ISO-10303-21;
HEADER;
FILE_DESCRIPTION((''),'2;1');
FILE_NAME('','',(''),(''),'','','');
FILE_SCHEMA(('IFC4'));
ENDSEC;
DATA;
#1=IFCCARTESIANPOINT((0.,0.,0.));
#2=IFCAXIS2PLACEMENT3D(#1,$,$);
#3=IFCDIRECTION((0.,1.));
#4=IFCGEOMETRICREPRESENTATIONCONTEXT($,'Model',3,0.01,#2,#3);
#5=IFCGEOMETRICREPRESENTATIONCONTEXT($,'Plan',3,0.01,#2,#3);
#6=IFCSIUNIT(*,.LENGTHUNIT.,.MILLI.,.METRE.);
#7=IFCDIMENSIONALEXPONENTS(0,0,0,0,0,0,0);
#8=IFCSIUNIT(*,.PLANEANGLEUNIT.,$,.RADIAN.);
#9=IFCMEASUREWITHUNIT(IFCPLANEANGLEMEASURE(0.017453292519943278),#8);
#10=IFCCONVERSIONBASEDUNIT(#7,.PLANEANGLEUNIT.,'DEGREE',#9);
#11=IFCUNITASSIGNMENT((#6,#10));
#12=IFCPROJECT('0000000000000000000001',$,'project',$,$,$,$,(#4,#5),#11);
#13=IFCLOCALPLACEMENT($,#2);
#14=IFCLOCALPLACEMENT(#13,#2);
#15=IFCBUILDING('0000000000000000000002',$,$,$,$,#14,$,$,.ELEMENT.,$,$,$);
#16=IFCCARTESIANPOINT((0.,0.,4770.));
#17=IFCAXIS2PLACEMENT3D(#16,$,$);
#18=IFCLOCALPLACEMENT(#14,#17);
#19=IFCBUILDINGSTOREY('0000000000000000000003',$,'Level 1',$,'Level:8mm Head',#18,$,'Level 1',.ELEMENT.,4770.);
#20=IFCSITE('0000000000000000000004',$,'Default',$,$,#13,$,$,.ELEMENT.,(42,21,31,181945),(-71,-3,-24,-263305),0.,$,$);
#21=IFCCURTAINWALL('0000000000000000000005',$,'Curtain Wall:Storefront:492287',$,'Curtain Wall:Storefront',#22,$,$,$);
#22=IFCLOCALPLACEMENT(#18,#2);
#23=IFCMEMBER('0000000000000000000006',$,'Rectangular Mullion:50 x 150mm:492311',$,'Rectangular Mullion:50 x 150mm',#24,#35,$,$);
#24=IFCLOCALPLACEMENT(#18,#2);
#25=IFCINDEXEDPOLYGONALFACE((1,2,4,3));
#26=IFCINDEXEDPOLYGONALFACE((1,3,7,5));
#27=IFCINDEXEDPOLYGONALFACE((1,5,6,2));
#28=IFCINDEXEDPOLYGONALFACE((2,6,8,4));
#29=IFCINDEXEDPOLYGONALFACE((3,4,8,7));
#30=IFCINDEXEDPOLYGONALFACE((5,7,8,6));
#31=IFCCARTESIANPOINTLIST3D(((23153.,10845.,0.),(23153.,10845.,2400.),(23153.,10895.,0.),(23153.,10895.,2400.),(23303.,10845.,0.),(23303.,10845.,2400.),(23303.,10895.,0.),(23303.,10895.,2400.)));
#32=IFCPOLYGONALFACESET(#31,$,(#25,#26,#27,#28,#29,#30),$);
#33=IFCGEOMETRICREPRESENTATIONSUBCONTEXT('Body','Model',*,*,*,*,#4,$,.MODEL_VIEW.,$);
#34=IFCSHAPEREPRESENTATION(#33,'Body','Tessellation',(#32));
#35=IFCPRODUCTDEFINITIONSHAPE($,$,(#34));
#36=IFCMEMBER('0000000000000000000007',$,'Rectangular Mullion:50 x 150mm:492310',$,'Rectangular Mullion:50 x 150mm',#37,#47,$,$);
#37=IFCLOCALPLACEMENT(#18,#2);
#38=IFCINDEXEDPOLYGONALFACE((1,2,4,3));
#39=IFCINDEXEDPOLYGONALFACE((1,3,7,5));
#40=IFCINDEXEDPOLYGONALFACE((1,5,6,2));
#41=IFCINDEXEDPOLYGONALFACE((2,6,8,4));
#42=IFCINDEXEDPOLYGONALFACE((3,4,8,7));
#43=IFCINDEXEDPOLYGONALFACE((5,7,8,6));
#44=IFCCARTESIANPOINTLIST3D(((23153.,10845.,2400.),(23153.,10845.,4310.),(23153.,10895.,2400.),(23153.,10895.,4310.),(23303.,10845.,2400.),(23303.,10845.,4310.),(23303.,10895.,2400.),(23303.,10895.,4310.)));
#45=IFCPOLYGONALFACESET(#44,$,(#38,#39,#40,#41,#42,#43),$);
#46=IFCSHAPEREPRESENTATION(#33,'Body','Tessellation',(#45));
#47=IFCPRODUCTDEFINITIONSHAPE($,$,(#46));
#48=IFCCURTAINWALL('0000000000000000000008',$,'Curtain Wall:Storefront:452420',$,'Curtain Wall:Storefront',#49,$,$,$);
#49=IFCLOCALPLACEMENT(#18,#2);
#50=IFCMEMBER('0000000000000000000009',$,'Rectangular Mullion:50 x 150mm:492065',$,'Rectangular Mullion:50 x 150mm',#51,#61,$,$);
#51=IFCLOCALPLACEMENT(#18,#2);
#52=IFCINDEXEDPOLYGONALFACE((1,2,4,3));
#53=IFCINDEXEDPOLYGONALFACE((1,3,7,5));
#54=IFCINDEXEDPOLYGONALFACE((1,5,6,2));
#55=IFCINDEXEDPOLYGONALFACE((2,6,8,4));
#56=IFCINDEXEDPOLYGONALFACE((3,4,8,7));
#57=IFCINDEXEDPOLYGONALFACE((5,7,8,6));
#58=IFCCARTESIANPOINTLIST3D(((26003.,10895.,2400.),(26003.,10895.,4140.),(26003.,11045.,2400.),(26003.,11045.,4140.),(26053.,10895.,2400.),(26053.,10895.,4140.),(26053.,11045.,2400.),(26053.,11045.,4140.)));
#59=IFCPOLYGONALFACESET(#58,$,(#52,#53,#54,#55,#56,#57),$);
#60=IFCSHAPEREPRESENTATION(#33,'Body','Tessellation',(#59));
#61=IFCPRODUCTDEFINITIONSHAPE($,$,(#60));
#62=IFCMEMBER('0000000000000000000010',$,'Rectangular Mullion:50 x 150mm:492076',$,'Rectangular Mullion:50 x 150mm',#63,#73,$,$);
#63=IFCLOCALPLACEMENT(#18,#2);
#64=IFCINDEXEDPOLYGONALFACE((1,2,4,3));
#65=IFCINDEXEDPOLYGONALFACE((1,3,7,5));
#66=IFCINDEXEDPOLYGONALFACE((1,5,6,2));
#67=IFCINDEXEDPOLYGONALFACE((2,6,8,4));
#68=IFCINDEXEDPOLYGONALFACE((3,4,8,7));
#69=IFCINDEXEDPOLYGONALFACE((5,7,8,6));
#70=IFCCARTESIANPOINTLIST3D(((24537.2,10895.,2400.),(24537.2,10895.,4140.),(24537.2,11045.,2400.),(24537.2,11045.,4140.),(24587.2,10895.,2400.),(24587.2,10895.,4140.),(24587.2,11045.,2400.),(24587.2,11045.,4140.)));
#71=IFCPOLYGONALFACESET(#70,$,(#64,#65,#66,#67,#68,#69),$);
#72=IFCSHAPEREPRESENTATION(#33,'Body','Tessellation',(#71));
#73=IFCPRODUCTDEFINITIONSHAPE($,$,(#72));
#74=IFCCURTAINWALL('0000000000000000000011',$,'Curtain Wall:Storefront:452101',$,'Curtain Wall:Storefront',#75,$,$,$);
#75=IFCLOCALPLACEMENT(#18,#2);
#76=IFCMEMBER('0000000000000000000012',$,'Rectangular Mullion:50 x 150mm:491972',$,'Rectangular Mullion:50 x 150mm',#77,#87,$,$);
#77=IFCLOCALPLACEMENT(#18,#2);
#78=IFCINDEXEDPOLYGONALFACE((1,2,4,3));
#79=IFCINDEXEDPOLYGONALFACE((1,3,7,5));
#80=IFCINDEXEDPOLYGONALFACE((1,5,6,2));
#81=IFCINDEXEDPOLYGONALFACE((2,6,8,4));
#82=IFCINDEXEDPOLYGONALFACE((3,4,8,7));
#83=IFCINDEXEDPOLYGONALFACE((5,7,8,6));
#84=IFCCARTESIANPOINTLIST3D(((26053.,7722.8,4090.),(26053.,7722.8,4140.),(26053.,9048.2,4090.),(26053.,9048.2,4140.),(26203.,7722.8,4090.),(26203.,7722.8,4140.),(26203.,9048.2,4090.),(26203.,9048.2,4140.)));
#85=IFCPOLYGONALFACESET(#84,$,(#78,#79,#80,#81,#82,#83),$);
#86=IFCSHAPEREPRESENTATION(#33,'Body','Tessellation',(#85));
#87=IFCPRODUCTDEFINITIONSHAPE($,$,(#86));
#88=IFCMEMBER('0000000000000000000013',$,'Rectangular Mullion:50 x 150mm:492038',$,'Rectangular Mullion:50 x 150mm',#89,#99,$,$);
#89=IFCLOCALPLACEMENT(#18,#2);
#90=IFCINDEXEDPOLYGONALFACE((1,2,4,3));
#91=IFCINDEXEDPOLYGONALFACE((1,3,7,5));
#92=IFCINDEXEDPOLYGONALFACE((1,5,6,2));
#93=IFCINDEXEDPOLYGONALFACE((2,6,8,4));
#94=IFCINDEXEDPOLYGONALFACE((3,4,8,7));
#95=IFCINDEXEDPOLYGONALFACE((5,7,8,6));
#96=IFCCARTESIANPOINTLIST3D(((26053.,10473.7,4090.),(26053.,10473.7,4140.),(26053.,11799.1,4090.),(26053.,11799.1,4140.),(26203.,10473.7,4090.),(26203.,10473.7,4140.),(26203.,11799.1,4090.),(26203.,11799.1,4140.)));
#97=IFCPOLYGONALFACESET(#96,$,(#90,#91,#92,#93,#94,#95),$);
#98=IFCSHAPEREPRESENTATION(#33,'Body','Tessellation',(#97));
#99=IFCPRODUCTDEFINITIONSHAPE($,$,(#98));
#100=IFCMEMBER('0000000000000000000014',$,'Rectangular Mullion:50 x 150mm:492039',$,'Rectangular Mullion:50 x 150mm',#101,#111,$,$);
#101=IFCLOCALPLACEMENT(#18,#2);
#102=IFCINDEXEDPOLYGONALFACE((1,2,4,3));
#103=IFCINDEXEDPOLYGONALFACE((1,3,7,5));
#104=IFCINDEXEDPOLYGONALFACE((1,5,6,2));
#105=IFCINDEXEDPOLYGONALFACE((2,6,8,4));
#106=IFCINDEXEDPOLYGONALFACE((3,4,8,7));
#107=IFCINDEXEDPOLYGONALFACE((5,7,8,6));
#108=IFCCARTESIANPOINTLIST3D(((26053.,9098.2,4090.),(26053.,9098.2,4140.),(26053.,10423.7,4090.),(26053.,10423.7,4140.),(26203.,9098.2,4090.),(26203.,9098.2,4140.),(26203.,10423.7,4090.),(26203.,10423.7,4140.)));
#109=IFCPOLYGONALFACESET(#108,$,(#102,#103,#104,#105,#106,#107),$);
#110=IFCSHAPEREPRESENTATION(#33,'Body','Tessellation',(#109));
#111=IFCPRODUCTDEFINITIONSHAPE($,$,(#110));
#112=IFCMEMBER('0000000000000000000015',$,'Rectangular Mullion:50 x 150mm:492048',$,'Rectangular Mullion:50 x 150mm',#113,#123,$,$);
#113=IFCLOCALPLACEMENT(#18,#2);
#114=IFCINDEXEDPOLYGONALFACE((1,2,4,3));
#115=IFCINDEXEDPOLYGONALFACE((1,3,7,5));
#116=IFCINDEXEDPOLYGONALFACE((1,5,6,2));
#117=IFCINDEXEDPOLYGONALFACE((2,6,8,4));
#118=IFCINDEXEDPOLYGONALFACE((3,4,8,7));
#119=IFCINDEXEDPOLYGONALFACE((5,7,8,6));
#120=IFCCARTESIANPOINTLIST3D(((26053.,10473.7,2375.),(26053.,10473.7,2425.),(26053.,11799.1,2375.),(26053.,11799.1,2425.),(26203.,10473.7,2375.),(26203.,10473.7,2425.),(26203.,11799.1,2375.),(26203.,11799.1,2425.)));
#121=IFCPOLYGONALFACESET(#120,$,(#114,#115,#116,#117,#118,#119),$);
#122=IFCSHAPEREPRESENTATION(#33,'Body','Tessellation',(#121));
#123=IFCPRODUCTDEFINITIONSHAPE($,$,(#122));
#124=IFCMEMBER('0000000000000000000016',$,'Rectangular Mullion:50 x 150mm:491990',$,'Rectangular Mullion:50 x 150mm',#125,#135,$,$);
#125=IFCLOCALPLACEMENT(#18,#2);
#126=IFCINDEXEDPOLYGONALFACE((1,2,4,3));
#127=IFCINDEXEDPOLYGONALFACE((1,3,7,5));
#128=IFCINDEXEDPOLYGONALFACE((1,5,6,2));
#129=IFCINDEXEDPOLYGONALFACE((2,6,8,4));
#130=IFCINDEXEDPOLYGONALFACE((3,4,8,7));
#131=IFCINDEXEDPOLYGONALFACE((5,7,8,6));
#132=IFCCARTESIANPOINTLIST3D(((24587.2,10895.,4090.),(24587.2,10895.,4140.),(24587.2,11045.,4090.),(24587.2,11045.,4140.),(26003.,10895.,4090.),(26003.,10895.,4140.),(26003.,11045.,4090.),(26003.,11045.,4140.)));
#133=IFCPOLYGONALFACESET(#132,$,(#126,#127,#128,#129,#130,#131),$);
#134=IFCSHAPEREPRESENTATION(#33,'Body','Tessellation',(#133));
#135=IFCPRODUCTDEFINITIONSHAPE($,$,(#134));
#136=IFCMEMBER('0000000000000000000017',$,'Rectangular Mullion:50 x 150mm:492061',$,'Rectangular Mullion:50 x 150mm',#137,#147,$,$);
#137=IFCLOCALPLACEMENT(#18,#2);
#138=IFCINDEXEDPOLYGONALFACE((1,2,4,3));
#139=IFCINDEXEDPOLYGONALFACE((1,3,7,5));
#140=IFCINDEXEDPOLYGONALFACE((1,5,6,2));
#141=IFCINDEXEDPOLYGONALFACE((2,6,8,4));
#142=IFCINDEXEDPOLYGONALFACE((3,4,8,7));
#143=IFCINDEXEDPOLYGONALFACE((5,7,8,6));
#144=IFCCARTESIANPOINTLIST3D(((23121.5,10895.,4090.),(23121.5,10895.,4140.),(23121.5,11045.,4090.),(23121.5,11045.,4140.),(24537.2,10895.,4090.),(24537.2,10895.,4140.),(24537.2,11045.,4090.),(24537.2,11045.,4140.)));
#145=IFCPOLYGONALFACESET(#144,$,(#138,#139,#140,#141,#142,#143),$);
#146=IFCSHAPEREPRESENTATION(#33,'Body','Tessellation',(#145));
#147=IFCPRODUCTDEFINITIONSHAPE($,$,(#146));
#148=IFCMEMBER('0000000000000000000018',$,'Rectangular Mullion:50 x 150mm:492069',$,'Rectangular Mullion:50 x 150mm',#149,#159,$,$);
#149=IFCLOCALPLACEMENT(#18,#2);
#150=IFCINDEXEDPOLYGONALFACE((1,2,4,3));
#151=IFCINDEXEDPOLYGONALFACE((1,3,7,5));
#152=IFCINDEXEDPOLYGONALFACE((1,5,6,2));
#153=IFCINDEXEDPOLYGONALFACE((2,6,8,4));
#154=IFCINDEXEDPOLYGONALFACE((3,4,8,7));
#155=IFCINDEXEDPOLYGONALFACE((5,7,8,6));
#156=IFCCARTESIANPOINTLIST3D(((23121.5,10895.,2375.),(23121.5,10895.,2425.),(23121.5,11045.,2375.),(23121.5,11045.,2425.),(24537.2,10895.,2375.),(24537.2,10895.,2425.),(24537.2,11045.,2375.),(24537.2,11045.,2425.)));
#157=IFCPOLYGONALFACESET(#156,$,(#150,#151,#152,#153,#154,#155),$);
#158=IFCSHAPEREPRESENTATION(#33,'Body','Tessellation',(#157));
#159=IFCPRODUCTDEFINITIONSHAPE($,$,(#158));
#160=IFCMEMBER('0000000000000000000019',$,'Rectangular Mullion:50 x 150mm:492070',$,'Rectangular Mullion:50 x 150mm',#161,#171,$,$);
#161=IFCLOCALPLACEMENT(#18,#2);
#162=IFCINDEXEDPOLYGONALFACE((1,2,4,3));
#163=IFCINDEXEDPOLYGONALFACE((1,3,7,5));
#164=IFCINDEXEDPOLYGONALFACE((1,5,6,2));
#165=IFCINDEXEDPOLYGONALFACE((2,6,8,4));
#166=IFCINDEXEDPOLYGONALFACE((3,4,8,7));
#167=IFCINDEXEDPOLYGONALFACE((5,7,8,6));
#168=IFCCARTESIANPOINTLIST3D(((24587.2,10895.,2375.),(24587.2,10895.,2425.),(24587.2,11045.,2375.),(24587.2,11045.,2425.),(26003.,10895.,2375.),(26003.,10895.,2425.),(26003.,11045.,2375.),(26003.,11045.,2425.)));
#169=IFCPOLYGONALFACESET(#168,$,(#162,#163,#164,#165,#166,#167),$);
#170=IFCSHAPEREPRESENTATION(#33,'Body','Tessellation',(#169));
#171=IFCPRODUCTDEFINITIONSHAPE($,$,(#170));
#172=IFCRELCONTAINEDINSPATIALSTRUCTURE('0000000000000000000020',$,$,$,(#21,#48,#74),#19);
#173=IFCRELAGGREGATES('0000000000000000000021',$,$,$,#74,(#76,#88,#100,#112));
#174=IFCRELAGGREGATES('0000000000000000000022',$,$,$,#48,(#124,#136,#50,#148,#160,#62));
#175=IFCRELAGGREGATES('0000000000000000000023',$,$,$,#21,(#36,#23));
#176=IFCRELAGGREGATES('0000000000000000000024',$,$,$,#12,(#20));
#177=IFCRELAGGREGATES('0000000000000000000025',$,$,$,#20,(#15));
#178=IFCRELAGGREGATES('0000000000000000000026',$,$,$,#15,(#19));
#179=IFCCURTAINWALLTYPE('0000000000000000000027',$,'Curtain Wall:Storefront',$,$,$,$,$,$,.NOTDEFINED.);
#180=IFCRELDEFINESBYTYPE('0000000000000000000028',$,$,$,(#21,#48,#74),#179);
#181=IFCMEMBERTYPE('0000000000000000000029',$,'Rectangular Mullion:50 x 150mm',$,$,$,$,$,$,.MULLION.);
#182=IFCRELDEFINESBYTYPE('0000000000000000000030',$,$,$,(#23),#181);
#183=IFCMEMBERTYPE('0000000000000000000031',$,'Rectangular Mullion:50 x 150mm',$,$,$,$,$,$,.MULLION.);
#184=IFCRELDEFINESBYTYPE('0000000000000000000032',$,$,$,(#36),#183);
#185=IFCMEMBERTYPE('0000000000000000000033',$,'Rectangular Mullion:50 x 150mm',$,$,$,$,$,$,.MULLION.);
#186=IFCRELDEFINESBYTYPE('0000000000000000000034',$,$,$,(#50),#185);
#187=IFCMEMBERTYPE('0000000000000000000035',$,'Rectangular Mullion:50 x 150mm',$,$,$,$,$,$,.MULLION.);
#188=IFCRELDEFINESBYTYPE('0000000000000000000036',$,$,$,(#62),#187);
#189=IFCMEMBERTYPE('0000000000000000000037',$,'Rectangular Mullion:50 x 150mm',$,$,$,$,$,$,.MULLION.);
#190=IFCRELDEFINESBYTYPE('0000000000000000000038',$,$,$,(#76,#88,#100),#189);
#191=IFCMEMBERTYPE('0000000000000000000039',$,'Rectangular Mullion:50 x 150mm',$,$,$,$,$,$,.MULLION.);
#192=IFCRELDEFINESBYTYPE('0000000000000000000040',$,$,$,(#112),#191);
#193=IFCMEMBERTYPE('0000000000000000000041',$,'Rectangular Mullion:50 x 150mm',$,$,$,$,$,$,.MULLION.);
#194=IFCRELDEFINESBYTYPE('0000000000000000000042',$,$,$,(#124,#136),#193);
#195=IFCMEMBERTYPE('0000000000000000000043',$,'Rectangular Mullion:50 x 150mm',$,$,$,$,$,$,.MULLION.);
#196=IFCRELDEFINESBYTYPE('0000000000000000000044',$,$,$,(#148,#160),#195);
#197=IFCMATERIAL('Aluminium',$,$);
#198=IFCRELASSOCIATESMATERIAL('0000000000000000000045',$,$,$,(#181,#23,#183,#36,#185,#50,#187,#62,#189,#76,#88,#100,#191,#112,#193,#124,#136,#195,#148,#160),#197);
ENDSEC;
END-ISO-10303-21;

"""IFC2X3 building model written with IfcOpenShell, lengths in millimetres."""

from ifc_helpers import new_model, entity, si_unit, converted_unit, direction, frame, origin, origin_2d_with_axis, place, context, subcontext, project, spatial, rectangle, extrude, source, transform, mapped, material, type_object, type_shapes, element, aggregate, save


model = new_model("IFC2X3")

# Units and contexts
model_context = context("Model", 3, precision=0.01, world=origin(), true_north=direction((0.0, 1.0)))
plan_context = context("Plan", 3, precision=0.01, world=origin(), true_north=direction((0.0, 1.0)))
body_context = subcontext(model_context, "Body", "Model", "MODEL_VIEW")
ifc_project = project(units=[si_unit("LENGTHUNIT", "METRE", prefix="MILLI"), converted_unit("PLANEANGLEUNIT", "DEGREE", entity("IfcPlaneAngleMeasure", 0.017453292519943278), si_unit("PLANEANGLEUNIT", "RADIAN"), dimensions=[0, 0, 0, 0, 0, 0, 0])], contexts=[model_context, plan_context])

# Site, building, storey
site_placement = place(None, origin())
site = spatial("IfcSite", under=ifc_project, at=site_placement, Name="Default", CompositionType="ELEMENT", RefLatitude=(42, 21, 31, 181945), RefLongitude=(-71, -3, -24, -263305), RefElevation=0.0)
building_placement = place(site_placement, origin())
building = spatial("IfcBuilding", under=site, at=building_placement, CompositionType="ELEMENT")
storey_placement = place(building_placement, frame((0.0, 0.0, 4770.0)))
storey = spatial("IfcBuildingStorey", under=building, at=storey_placement, Name="Level 1", ObjectType="Level:8mm Head", LongName="Level 1", CompositionType="ELEMENT", Elevation=4770.0)

# Curtain walls, members
curtain_wall_type = type_object("IfcCurtainWallType", Name="Curtain Wall:Storefront", PredefinedType="NOTDEFINED")
curtain_wall_1_placement = place(storey_placement, frame((0.0, 0.0, -4770.0)))
curtain_wall_1 = element("IfcCurtainWall", 1, at=curtain_wall_1_placement, inside=storey, type_object=curtain_wall_type, Name="Curtain Wall:Storefront:492287", ObjectType="Curtain Wall:Storefront")
ifc_material_1 = material(Name="Aluminium")
member_type_1 = type_object("IfcMemberType", Name="Rectangular Mullion:50 x 150mm", PredefinedType="MULLION", material=ifc_material_1)
shared_shape_1 = source(origin(), body_context, "Body", "SweptSolid", [
    extrude(rectangle(XDim=50.0, YDim=150.0, at=origin_2d_with_axis()), frame((-25.0, 0.0, -2400.0), z_axis=(0.0, 0.0, 1.0), x_axis=(-1.0, 0.0, 0.0)), (0.0, 0.0, 1.0), 2400.0),
])
type_shapes(member_type_1, [shared_shape_1])
member_1_placement = place(curtain_wall_1_placement, frame((23228.0, 10895.0, 7170.0), z_axis=(0.0, 0.0, 1.0), x_axis=(0.0, 1.0, 0.0)))
member_1 = element("IfcMember", 2, at=member_1_placement, type_object=member_type_1, material=ifc_material_1, Name="Rectangular Mullion:50 x 150mm:492311", ObjectType="Rectangular Mullion:50 x 150mm", context=body_context, shape_type="MappedRepresentation", body=[
    mapped(shared_shape_1, transform((0.0, 0.0, 0.0), scale=1.0)),
])
member_type_2 = type_object("IfcMemberType", Name="Rectangular Mullion:50 x 150mm", PredefinedType="MULLION", material=ifc_material_1)
shared_shape_2 = source(origin(), body_context, "Body", "SweptSolid", [
    extrude(rectangle(XDim=50.0, YDim=150.0, at=origin_2d_with_axis()), frame((-25.0, 0.0, -1910.0), z_axis=(0.0, 0.0, 1.0), x_axis=(-1.0, 0.0, 0.0)), (0.0, 0.0, 1.0), 1910.0),
])
type_shapes(member_type_2, [shared_shape_2])
member_2_placement = place(curtain_wall_1_placement, frame((23228.0, 10895.0, 9080.0), z_axis=(0.0, 0.0, 1.0), x_axis=(0.0, 1.0, 0.0)))
member_2 = element("IfcMember", 3, at=member_2_placement, type_object=member_type_2, material=ifc_material_1, Name="Rectangular Mullion:50 x 150mm:492310", ObjectType="Rectangular Mullion:50 x 150mm", context=body_context, shape_type="MappedRepresentation", body=[
    mapped(shared_shape_2, transform((0.0, 0.0, 0.0), scale=1.0)),
])
curtain_wall_2_placement = place(storey_placement, frame((0.0, 0.0, -4770.0)))
curtain_wall_2 = element("IfcCurtainWall", 4, at=curtain_wall_2_placement, inside=storey, type_object=curtain_wall_type, Name="Curtain Wall:Storefront:452420", ObjectType="Curtain Wall:Storefront")
member_type_3 = type_object("IfcMemberType", Name="Rectangular Mullion:50 x 150mm", PredefinedType="MULLION", material=ifc_material_1)
shared_shape_3 = source(origin(), body_context, "Body", "SweptSolid", [
    extrude(rectangle(XDim=50.0, YDim=150.0, at=origin_2d_with_axis()), frame((-25.0, 0.0, -1740.0), z_axis=(0.0, 0.0, 1.0), x_axis=(-1.0, 0.0, 0.0)), (0.0, 0.0, 1.0), 1740.0),
])
type_shapes(member_type_3, [shared_shape_3])
member_3_placement = place(curtain_wall_2_placement, frame((26053.0, 10970.0, 7170.0), z_axis=(0.0, 0.0, -1.0), x_axis=(1.0, 0.0, 0.0)))
member_3 = element("IfcMember", 5, at=member_3_placement, type_object=member_type_3, material=ifc_material_1, Name="Rectangular Mullion:50 x 150mm:492065", ObjectType="Rectangular Mullion:50 x 150mm", context=body_context, shape_type="MappedRepresentation", body=[
    mapped(shared_shape_3, transform((0.0, 0.0, 0.0), scale=1.0)),
])
member_type_4 = type_object("IfcMemberType", Name="Rectangular Mullion:50 x 150mm", PredefinedType="MULLION", material=ifc_material_1)
shared_shape_4 = source(origin(), body_context, "Body", "SweptSolid", [
    extrude(rectangle(XDim=50.0, YDim=150.0, at=origin_2d_with_axis()), frame((0.0, 0.0, -1740.0), z_axis=(0.0, 0.0, 1.0), x_axis=(-1.0, 0.0, 0.0)), (0.0, 0.0, 1.0), 1740.0),
])
type_shapes(member_type_4, [shared_shape_4])
member_4_placement = place(curtain_wall_2_placement, frame((24562.2, 10970.0, 7170.0), z_axis=(0.0, 0.0, -1.0), x_axis=(1.0, 0.0, 0.0)))
member_4 = element("IfcMember", 6, at=member_4_placement, type_object=member_type_4, material=ifc_material_1, Name="Rectangular Mullion:50 x 150mm:492076", ObjectType="Rectangular Mullion:50 x 150mm", context=body_context, shape_type="MappedRepresentation", body=[
    mapped(shared_shape_4, transform((0.0, 0.0, 0.0), scale=1.0)),
])
curtain_wall_3_placement = place(storey_placement, frame((0.0, 0.0, -4770.0)))
curtain_wall_3 = element("IfcCurtainWall", 7, at=curtain_wall_3_placement, inside=storey, type_object=curtain_wall_type, Name="Curtain Wall:Storefront:452101", ObjectType="Curtain Wall:Storefront")
member_type_5 = type_object("IfcMemberType", Name="Rectangular Mullion:50 x 150mm", PredefinedType="MULLION", material=ifc_material_1)
shared_shape_5 = source(origin(), body_context, "Body", "SweptSolid", [
    extrude(rectangle(XDim=50.0, YDim=150.0, at=origin_2d_with_axis()), frame((-25.0, 0.0, -1325.4), z_axis=(0.0, 0.0, 1.0), x_axis=(-1.0, 0.0, 0.0)), (0.0, 0.0, 1.0), 1325.4),
])
type_shapes(member_type_5, [shared_shape_5])
member_5_placement = place(curtain_wall_3_placement, frame((26128.0, 7722.8, 8910.0), z_axis=(0.0, -1.0, 0.0), x_axis=(0.0, 0.0, 1.0)))
member_5 = element("IfcMember", 8, at=member_5_placement, type_object=member_type_5, material=ifc_material_1, Name="Rectangular Mullion:50 x 150mm:491972", ObjectType="Rectangular Mullion:50 x 150mm", context=body_context, shape_type="MappedRepresentation", body=[
    mapped(shared_shape_5, transform((0.0, 0.0, 0.0), scale=1.0)),
])
member_6_placement = place(curtain_wall_3_placement, frame((26128.0, 10473.7, 8910.0), z_axis=(0.0, -1.0, 0.0), x_axis=(0.0, 0.0, 1.0)))
member_6 = element("IfcMember", 9, at=member_6_placement, type_object=member_type_5, material=ifc_material_1, Name="Rectangular Mullion:50 x 150mm:492038", ObjectType="Rectangular Mullion:50 x 150mm", context=body_context, shape_type="MappedRepresentation", body=[
    mapped(shared_shape_5, transform((0.0, 0.0, 0.0), scale=1.0)),
])
member_7_placement = place(curtain_wall_3_placement, frame((26128.0, 9098.2, 8910.0), z_axis=(0.0, -1.0, 0.0), x_axis=(0.0, 0.0, 1.0)))
member_7 = element("IfcMember", 10, at=member_7_placement, type_object=member_type_5, material=ifc_material_1, Name="Rectangular Mullion:50 x 150mm:492039", ObjectType="Rectangular Mullion:50 x 150mm", context=body_context, shape_type="MappedRepresentation", body=[
    mapped(shared_shape_5, transform((0.0, 0.0, 0.0), scale=1.0)),
])
member_type_6 = type_object("IfcMemberType", Name="Rectangular Mullion:50 x 150mm", PredefinedType="MULLION", material=ifc_material_1)
shared_shape_6 = source(origin(), body_context, "Body", "SweptSolid", [
    extrude(rectangle(XDim=50.0, YDim=150.0, at=origin_2d_with_axis()), frame((0.0, 0.0, -1325.4), z_axis=(0.0, 0.0, 1.0), x_axis=(-1.0, 0.0, 0.0)), (0.0, 0.0, 1.0), 1325.4),
])
type_shapes(member_type_6, [shared_shape_6])
member_8_placement = place(curtain_wall_3_placement, frame((26128.0, 10473.7, 7170.0), z_axis=(0.0, -1.0, 0.0), x_axis=(0.0, 0.0, 1.0)))
member_8 = element("IfcMember", 11, at=member_8_placement, type_object=member_type_6, material=ifc_material_1, Name="Rectangular Mullion:50 x 150mm:492048", ObjectType="Rectangular Mullion:50 x 150mm", context=body_context, shape_type="MappedRepresentation", body=[
    mapped(shared_shape_6, transform((0.0, 0.0, 0.0), scale=1.0)),
])

# Members
member_type_7 = type_object("IfcMemberType", Name="Rectangular Mullion:50 x 150mm", PredefinedType="MULLION", material=ifc_material_1)
shared_shape_7 = source(origin(), body_context, "Body", "SweptSolid", [
    extrude(rectangle(XDim=50.0, YDim=150.0, at=origin_2d_with_axis()), frame((-25.0, 0.0, -1415.7), z_axis=(0.0, 0.0, 1.0), x_axis=(-1.0, 0.0, 0.0)), (0.0, 0.0, 1.0), 1415.7),
])
type_shapes(member_type_7, [shared_shape_7])
member_9_placement = place(curtain_wall_2_placement, frame((26003.0, 10970.0, 8910.0), z_axis=(1.0, 0.0, 0.0), x_axis=(0.0, 0.0, 1.0)))
member_9 = element("IfcMember", 12, at=member_9_placement, type_object=member_type_7, material=ifc_material_1, Name="Rectangular Mullion:50 x 150mm:491990", ObjectType="Rectangular Mullion:50 x 150mm", context=body_context, shape_type="MappedRepresentation", body=[
    mapped(shared_shape_7, transform((0.0, 0.0, 0.0), scale=1.0)),
])
member_10_placement = place(curtain_wall_2_placement, frame((24537.2, 10970.0, 8910.0), z_axis=(1.0, 0.0, 0.0), x_axis=(0.0, 0.0, 1.0)))
member_10 = element("IfcMember", 13, at=member_10_placement, type_object=member_type_7, material=ifc_material_1, Name="Rectangular Mullion:50 x 150mm:492061", ObjectType="Rectangular Mullion:50 x 150mm", context=body_context, shape_type="MappedRepresentation", body=[
    mapped(shared_shape_7, transform((0.0, 0.0, 0.0), scale=1.0)),
])
member_type_8 = type_object("IfcMemberType", Name="Rectangular Mullion:50 x 150mm", PredefinedType="MULLION", material=ifc_material_1)
shared_shape_8 = source(origin(), body_context, "Body", "SweptSolid", [
    extrude(rectangle(XDim=50.0, YDim=150.0, at=origin_2d_with_axis()), frame((0.0, 0.0, -1415.7), z_axis=(0.0, 0.0, 1.0), x_axis=(-1.0, 0.0, 0.0)), (0.0, 0.0, 1.0), 1415.7),
])
type_shapes(member_type_8, [shared_shape_8])
member_11_placement = place(curtain_wall_2_placement, frame((24537.2, 10970.0, 7170.0), z_axis=(1.0, 0.0, 0.0), x_axis=(0.0, 0.0, 1.0)))
member_11 = element("IfcMember", 14, at=member_11_placement, type_object=member_type_8, material=ifc_material_1, Name="Rectangular Mullion:50 x 150mm:492069", ObjectType="Rectangular Mullion:50 x 150mm", context=body_context, shape_type="MappedRepresentation", body=[
    mapped(shared_shape_8, transform((0.0, 0.0, 0.0), scale=1.0)),
])
member_12_placement = place(curtain_wall_2_placement, frame((26003.0, 10970.0, 7170.0), z_axis=(1.0, 0.0, 0.0), x_axis=(0.0, 0.0, 1.0)))
member_12 = element("IfcMember", 15, at=member_12_placement, type_object=member_type_8, material=ifc_material_1, Name="Rectangular Mullion:50 x 150mm:492070", ObjectType="Rectangular Mullion:50 x 150mm", context=body_context, shape_type="MappedRepresentation", body=[
    mapped(shared_shape_8, transform((0.0, 0.0, 0.0), scale=1.0)),
])

aggregate(curtain_wall_3, [member_5, member_6, member_7, member_8])
aggregate(curtain_wall_2, [member_9, member_10, member_3, member_11, member_12, member_4])
aggregate(curtain_wall_1, [member_2, member_1])

save(model, "model.ifc")
